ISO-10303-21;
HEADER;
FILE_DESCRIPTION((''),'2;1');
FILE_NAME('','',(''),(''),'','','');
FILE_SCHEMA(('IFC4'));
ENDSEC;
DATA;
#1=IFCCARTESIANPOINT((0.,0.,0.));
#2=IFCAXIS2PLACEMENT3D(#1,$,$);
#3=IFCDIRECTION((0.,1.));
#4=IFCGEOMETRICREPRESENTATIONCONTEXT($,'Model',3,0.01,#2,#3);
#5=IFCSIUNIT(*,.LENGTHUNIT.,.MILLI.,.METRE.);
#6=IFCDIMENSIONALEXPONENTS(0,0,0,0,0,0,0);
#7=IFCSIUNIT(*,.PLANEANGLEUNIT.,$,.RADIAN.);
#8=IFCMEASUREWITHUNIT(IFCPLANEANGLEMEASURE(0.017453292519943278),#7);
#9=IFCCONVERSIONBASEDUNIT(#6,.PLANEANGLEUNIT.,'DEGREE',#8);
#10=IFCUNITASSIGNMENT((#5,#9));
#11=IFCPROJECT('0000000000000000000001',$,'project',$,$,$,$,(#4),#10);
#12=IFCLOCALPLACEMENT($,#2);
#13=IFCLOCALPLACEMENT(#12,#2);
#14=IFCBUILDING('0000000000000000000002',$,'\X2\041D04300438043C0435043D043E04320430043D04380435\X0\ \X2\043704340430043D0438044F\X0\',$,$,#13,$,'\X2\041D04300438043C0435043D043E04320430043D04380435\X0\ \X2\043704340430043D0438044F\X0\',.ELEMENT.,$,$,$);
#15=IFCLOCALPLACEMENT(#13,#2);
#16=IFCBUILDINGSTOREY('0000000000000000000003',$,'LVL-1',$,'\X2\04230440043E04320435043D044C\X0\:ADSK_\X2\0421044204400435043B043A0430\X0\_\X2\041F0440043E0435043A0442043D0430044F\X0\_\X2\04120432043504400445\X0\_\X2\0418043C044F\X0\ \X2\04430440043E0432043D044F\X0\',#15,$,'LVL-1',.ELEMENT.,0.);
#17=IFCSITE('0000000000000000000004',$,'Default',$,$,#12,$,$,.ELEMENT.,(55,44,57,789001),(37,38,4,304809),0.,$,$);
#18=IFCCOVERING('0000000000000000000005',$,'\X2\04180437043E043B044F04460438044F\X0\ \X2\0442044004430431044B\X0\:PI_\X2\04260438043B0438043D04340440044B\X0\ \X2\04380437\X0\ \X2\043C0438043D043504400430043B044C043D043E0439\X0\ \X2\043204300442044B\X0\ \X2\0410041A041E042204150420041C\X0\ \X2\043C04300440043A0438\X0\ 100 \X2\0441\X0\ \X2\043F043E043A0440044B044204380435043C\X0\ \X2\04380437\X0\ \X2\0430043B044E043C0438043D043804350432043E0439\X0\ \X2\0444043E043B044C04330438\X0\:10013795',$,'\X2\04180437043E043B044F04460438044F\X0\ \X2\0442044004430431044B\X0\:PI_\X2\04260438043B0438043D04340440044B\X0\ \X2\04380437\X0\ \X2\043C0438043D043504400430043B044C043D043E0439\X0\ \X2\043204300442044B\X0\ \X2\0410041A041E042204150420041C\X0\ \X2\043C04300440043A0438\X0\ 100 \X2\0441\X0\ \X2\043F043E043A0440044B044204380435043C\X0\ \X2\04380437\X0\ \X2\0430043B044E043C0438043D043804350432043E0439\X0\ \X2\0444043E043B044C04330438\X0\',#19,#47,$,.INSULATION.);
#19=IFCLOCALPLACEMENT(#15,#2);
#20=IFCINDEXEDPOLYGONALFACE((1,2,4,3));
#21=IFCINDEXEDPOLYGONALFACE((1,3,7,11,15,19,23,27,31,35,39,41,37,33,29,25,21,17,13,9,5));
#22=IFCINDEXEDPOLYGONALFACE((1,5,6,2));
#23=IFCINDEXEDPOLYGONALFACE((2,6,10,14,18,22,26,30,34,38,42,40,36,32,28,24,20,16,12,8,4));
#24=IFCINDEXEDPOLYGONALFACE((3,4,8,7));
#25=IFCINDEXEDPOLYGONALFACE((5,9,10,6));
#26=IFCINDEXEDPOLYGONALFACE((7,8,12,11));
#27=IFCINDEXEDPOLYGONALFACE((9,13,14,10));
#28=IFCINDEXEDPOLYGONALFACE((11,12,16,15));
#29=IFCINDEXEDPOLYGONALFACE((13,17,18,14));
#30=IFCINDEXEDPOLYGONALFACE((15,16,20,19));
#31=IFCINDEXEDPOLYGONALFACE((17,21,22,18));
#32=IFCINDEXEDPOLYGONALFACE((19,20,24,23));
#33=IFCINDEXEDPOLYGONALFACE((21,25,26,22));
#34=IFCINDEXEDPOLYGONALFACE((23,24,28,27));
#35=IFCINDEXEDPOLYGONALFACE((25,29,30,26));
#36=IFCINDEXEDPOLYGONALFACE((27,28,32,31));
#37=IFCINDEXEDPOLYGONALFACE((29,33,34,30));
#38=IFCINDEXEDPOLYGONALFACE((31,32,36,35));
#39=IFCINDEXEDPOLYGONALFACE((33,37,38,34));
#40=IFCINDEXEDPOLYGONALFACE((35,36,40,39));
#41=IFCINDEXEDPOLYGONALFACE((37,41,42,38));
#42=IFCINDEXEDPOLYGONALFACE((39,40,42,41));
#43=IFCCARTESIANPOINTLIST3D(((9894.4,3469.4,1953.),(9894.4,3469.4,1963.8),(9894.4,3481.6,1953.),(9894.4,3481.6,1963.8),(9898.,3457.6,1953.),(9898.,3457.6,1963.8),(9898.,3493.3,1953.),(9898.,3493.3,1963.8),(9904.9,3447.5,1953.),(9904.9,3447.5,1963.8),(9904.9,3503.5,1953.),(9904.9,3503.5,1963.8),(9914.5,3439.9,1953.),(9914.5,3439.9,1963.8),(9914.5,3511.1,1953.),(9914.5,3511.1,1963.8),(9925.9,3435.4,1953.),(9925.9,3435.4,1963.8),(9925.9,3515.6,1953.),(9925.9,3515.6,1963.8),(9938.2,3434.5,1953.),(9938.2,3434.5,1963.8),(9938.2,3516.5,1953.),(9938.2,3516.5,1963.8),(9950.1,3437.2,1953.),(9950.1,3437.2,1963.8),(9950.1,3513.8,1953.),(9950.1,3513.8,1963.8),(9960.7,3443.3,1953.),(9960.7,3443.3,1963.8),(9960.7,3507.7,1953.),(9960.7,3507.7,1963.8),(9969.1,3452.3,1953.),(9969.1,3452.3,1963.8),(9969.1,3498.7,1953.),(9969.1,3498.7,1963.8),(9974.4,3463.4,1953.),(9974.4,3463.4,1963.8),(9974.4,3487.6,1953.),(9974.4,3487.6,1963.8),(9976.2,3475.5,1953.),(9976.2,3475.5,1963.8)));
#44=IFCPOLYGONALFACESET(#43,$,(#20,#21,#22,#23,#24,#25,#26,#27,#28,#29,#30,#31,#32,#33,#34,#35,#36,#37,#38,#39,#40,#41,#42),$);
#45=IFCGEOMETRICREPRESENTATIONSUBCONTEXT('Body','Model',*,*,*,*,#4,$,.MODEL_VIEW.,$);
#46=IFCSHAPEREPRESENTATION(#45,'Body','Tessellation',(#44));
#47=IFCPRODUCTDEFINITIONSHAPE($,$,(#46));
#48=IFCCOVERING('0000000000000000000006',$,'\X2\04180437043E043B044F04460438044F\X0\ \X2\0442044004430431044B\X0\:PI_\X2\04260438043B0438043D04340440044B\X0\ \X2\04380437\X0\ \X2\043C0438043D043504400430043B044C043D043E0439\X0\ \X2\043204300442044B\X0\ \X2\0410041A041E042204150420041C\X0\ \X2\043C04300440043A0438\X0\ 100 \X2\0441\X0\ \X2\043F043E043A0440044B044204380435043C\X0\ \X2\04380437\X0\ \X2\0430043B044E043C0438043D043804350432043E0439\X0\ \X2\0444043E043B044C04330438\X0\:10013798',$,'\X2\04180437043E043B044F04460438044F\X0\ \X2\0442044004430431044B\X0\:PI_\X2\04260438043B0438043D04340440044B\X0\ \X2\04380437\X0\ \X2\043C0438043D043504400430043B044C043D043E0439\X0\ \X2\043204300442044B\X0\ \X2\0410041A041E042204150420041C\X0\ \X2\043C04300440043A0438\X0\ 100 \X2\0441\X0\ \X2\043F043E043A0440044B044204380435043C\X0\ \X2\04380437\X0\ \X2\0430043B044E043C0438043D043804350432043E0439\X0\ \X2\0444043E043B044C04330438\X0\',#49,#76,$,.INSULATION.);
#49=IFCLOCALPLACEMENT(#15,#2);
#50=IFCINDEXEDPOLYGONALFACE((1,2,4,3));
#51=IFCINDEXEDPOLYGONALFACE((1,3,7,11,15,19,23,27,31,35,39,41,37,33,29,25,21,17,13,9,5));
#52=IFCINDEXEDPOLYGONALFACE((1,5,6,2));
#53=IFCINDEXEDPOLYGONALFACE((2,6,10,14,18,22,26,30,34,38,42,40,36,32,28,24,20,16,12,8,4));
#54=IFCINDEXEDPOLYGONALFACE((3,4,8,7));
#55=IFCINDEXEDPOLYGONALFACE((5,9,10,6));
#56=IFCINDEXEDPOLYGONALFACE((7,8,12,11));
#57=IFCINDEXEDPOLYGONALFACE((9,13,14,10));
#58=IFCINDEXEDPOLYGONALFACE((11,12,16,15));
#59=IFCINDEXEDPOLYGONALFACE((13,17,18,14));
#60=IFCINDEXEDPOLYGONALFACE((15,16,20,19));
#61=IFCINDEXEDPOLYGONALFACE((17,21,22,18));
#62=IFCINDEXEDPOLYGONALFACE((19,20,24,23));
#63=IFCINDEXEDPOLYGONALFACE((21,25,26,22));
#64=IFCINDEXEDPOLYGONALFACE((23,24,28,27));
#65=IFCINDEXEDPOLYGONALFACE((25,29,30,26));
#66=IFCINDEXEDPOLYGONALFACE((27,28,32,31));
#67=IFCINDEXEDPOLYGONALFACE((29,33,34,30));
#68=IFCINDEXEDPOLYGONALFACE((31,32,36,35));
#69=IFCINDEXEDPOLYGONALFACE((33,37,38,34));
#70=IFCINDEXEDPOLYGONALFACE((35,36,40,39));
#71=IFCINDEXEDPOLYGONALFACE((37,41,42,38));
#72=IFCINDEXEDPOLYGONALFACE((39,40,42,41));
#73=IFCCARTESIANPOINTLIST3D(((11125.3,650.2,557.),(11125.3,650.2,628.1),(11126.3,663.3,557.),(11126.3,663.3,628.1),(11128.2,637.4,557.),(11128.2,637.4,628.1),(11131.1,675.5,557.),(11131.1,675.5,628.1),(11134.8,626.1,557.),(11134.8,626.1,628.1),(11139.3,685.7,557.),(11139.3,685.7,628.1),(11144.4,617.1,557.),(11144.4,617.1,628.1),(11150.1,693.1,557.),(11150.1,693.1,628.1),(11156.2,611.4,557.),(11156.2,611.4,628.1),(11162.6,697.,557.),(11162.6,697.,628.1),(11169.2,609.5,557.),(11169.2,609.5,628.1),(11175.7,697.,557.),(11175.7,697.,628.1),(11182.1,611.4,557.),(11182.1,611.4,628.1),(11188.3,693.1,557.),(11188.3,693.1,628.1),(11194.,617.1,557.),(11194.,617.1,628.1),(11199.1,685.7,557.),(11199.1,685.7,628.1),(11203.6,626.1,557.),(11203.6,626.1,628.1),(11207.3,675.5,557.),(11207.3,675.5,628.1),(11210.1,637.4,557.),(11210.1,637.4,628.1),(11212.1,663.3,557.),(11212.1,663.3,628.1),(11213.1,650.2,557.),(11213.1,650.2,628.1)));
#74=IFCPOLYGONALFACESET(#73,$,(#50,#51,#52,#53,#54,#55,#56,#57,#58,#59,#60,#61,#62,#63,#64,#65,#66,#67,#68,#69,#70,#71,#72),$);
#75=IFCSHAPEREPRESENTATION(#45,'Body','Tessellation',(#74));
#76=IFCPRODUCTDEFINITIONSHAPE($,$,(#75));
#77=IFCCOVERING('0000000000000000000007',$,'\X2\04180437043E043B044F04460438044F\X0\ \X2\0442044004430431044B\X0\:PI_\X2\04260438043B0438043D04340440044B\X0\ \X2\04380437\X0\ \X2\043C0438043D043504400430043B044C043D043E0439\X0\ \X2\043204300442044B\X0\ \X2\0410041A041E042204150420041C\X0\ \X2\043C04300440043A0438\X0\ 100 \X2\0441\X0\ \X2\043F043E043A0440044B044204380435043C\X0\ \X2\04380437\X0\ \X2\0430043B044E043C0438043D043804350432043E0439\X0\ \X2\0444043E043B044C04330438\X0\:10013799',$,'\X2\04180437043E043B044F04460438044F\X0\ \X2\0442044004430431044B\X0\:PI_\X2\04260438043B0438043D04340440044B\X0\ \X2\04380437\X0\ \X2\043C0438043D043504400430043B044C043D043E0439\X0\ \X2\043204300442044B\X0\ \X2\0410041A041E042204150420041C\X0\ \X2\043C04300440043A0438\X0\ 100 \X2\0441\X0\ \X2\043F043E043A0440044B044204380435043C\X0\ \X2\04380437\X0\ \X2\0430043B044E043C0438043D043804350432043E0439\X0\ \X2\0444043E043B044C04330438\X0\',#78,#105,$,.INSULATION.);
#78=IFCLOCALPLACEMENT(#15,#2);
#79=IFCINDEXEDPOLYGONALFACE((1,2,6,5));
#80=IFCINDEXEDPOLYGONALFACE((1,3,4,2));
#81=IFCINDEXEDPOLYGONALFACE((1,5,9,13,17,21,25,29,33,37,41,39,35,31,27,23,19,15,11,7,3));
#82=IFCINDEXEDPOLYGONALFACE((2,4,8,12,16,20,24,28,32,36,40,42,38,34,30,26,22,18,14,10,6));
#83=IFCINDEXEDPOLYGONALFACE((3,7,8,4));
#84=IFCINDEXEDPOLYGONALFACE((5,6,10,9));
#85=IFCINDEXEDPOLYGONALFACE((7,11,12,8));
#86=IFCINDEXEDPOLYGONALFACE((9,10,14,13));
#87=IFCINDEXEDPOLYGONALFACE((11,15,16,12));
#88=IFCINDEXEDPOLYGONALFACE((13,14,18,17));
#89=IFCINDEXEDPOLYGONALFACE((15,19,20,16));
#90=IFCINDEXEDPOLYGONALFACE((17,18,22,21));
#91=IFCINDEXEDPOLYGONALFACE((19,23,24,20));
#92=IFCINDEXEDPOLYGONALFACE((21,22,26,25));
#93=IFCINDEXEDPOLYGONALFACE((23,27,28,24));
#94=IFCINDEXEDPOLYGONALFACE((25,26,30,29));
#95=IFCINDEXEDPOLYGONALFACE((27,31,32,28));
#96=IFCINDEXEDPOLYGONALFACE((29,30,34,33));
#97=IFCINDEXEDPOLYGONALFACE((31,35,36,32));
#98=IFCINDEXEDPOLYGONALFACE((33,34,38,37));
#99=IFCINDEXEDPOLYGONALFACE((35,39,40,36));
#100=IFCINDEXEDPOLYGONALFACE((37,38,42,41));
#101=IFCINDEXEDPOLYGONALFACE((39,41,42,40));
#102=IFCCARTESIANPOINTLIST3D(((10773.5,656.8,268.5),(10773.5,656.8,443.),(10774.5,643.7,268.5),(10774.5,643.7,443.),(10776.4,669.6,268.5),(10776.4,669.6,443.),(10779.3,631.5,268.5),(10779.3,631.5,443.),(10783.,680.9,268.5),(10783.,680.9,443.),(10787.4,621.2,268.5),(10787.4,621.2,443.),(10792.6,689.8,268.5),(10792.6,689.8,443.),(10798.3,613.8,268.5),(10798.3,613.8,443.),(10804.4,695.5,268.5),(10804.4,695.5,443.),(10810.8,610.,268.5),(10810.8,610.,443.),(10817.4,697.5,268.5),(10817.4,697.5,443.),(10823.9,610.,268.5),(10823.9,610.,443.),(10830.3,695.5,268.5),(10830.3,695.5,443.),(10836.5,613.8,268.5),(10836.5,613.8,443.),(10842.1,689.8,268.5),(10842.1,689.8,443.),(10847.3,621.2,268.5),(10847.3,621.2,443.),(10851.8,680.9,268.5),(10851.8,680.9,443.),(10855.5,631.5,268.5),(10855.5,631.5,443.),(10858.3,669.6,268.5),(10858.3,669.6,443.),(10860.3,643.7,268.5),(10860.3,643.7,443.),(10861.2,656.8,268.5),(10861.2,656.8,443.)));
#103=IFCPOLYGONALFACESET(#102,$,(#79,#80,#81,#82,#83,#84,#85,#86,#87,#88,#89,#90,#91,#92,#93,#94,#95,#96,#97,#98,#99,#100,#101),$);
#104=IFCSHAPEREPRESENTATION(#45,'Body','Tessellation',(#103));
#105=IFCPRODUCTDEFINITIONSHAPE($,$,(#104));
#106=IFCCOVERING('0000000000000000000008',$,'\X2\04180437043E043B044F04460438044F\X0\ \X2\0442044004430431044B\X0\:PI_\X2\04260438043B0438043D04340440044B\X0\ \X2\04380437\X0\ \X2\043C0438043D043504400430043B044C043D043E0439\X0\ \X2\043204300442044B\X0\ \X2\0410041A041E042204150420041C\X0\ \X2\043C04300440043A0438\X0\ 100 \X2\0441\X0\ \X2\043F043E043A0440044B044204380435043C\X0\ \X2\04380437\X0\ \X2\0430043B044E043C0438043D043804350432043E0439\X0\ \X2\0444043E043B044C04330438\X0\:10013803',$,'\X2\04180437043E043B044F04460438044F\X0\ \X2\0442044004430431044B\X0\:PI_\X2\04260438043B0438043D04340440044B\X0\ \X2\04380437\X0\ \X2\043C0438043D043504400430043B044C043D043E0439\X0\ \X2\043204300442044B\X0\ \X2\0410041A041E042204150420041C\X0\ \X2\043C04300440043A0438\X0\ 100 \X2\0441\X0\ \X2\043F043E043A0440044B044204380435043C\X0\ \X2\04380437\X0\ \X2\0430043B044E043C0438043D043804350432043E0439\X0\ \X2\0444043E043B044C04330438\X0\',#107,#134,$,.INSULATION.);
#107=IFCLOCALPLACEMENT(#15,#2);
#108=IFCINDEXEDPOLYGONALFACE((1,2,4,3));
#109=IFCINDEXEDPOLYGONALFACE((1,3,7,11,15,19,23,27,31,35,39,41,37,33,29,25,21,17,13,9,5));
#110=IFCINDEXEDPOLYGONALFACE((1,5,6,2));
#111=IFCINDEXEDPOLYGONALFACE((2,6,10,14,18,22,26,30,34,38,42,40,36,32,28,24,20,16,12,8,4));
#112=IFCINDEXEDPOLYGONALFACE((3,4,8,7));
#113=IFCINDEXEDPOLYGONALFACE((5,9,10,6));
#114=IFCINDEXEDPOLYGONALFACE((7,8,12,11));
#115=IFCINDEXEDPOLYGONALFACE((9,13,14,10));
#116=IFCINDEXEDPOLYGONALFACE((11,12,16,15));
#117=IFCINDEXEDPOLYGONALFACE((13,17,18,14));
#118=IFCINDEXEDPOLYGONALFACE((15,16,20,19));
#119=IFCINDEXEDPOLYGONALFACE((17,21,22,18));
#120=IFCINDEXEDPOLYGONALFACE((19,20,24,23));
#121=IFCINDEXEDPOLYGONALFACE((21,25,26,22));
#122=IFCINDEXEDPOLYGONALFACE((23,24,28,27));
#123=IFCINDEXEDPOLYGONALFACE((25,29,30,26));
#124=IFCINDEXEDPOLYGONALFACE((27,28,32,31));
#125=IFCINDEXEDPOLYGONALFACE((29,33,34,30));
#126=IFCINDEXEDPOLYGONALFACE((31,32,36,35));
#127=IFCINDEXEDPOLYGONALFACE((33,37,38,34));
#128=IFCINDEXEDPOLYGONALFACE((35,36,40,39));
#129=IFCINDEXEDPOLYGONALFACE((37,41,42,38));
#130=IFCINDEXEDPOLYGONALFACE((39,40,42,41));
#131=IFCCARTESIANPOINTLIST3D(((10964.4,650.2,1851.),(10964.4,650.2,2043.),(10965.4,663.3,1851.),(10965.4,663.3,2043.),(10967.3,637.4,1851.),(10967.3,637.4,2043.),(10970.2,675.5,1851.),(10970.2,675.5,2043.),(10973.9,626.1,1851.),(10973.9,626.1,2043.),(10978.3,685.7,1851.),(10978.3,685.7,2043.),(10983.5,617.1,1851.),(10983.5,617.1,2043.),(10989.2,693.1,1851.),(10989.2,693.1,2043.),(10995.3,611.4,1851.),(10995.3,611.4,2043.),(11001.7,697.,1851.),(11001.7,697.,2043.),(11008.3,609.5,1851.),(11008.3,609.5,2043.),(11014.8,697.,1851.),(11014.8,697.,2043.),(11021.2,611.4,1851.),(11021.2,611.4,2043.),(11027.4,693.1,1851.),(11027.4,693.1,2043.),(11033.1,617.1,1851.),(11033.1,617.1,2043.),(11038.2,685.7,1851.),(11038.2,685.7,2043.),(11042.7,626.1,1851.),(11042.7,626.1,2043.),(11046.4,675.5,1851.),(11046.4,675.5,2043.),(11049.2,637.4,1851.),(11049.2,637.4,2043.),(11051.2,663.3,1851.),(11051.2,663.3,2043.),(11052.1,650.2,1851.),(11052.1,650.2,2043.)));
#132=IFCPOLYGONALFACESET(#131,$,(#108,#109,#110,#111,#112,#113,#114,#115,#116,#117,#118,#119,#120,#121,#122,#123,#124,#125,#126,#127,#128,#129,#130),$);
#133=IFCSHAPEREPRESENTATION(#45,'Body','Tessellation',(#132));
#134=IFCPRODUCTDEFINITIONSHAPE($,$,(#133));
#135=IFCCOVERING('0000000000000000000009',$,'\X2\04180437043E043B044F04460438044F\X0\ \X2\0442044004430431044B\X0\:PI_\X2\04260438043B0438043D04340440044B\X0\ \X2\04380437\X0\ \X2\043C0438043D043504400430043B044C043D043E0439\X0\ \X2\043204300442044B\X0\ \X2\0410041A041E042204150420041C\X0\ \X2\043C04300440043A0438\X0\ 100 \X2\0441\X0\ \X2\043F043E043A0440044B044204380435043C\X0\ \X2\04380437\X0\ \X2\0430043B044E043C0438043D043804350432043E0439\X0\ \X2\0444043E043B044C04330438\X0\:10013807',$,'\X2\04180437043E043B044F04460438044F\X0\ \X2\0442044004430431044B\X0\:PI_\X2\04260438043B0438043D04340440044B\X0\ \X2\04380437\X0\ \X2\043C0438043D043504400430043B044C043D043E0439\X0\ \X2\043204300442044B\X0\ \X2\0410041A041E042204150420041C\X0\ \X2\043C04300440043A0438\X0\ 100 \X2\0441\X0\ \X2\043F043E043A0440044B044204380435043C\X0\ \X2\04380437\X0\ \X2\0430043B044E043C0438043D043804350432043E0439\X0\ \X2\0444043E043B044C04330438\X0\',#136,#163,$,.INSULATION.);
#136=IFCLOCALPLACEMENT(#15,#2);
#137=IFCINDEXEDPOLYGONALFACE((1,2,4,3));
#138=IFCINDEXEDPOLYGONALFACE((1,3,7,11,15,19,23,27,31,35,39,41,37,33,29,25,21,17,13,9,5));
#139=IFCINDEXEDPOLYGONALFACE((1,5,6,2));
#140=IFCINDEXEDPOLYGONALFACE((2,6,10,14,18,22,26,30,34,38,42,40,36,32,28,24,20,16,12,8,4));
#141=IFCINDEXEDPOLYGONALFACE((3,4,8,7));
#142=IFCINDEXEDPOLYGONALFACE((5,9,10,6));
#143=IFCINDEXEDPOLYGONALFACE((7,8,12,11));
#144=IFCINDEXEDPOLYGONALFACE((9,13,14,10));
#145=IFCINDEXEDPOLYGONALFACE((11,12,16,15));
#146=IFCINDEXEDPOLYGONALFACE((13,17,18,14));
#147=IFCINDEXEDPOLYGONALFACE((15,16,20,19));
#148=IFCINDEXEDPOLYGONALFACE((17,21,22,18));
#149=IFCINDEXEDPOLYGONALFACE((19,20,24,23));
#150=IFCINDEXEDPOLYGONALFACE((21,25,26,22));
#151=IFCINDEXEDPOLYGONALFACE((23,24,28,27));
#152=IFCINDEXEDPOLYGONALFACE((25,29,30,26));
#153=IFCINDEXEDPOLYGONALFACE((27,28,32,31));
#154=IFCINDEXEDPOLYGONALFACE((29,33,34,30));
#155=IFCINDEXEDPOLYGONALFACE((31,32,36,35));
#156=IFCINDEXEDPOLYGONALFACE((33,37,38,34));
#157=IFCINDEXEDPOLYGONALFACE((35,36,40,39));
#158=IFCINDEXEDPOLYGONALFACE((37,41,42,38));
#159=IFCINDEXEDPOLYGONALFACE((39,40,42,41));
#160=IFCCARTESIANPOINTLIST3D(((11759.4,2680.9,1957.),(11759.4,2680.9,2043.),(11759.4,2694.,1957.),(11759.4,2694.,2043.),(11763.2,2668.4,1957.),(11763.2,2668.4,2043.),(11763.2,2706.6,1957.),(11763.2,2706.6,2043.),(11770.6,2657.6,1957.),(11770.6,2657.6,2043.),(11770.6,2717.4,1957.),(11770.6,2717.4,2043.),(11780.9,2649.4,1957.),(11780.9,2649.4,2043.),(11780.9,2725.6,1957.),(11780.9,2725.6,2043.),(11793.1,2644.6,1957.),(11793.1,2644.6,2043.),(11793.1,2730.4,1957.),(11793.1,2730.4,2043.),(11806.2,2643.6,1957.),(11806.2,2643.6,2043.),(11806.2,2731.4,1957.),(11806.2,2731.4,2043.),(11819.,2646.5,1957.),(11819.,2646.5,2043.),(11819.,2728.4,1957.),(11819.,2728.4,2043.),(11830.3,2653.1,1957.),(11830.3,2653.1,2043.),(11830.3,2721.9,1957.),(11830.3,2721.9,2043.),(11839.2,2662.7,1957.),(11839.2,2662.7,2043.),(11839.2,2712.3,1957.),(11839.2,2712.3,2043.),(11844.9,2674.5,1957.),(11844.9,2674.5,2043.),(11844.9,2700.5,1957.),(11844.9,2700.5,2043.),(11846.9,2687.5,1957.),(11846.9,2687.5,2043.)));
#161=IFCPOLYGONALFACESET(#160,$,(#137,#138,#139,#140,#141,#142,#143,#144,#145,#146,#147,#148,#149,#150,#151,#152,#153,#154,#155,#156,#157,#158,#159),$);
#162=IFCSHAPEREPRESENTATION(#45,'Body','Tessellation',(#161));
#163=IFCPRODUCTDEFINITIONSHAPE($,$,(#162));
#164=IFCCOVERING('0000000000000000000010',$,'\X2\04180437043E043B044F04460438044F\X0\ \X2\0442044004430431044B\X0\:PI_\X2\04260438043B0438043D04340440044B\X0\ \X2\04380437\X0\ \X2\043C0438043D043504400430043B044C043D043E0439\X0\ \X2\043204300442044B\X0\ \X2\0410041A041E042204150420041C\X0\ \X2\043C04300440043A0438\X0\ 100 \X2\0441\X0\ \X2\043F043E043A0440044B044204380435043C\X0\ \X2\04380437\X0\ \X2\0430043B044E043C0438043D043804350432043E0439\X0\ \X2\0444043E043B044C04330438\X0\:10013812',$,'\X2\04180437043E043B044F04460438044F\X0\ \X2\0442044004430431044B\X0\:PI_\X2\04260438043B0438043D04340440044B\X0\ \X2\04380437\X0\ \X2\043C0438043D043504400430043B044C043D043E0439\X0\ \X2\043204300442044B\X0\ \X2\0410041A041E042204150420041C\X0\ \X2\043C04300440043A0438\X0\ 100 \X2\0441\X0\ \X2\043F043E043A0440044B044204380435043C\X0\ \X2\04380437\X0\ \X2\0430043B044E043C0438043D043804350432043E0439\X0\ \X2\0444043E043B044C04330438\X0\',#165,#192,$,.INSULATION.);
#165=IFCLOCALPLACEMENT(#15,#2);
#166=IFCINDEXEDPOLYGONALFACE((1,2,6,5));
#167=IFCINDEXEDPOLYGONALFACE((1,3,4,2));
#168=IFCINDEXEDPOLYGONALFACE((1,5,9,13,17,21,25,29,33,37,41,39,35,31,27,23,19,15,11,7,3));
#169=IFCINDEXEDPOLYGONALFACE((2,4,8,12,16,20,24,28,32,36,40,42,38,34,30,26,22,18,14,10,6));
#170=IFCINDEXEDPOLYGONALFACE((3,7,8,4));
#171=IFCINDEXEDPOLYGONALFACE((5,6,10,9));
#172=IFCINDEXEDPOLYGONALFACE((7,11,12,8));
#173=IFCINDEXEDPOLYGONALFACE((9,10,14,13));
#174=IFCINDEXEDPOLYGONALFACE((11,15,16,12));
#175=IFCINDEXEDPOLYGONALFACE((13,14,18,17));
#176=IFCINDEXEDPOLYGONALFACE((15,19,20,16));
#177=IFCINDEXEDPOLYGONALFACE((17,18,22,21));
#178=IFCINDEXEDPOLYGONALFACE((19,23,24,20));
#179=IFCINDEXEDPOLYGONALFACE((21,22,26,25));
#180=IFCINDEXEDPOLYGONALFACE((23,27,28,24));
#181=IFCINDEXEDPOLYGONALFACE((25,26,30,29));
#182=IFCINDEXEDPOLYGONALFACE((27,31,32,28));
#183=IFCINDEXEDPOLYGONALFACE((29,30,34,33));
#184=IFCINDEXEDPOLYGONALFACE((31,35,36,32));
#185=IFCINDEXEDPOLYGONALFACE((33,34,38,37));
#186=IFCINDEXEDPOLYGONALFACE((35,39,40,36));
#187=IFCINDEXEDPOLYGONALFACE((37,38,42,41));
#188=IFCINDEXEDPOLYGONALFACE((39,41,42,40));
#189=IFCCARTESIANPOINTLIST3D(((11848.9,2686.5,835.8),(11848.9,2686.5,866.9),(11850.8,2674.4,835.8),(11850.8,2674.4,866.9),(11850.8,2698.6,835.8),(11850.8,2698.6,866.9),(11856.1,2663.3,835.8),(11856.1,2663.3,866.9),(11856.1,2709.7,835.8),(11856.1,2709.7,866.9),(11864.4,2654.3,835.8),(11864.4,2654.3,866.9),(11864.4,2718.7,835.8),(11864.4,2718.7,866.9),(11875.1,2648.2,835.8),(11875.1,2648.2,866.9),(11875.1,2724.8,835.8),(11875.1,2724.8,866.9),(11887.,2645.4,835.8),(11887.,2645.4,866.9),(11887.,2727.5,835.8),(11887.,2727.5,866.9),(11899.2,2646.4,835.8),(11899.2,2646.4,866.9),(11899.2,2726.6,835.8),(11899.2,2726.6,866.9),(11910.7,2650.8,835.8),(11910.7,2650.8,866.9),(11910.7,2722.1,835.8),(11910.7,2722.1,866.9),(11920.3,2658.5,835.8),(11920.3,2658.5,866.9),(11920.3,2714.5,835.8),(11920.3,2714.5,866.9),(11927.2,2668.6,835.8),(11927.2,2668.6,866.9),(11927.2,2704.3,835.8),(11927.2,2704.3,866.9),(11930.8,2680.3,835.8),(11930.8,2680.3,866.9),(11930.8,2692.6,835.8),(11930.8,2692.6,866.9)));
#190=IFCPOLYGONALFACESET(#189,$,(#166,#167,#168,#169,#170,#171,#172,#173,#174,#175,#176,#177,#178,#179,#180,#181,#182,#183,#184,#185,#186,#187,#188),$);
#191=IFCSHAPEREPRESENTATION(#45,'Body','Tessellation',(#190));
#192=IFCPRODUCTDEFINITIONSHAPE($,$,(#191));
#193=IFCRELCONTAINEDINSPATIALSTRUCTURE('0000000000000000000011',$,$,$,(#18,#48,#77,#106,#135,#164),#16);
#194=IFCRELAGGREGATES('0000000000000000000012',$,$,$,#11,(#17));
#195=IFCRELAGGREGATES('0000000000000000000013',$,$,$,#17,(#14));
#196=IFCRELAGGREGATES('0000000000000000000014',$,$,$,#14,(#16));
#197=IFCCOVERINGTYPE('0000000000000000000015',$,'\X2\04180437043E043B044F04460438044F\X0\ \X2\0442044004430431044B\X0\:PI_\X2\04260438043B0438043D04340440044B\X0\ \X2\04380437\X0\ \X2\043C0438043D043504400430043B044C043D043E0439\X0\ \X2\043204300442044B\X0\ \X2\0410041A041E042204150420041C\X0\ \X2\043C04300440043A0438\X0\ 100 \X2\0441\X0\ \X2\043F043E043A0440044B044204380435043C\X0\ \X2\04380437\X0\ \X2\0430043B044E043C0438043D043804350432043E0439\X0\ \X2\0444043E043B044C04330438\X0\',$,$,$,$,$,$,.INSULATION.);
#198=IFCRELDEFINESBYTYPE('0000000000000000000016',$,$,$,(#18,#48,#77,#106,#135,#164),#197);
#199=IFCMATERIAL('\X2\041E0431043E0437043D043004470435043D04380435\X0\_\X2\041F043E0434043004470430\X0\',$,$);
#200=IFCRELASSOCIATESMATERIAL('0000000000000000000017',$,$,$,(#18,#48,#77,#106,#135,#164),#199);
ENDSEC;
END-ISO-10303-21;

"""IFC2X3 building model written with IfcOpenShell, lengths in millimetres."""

from ifc_helpers import new_model, entity, si_unit, converted_unit, direction, frame, frame_2d, origin, origin_2d_with_axis, place, context, subcontext, project, spatial, circle, extrude, material, type_object, element, save


model = new_model("IFC2X3")

# Units and contexts
model_context = context("Model", 3, precision=0.01, world=origin(), true_north=direction((0.0, 1.0)))
body_context = subcontext(model_context, "Body", "Model", "MODEL_VIEW")
ifc_project = project(units=[si_unit("LENGTHUNIT", "METRE", prefix="MILLI"), converted_unit("PLANEANGLEUNIT", "DEGREE", entity("IfcPlaneAngleMeasure", 0.017453292519943278), si_unit("PLANEANGLEUNIT", "RADIAN"), dimensions=[0, 0, 0, 0, 0, 0, 0])], contexts=[model_context])

# Site, building, storey
site_placement = place(None, origin())
site = spatial("IfcSite", under=ifc_project, at=site_placement, Name="Default", CompositionType="ELEMENT", RefLatitude=(55, 44, 57, 789001), RefLongitude=(37, 38, 4, 304809), RefElevation=0.0)
building_placement = place(site_placement, origin())
building = spatial("IfcBuilding", under=site, at=building_placement, Name="Наименование здания", LongName="Наименование здания", CompositionType="ELEMENT")
storey_placement = place(building_placement, origin())
storey = spatial("IfcBuildingStorey", under=building, at=storey_placement, Name="LVL-1", ObjectType="Уровень:ADSK_Стрелка_Проектная_Вверх_Имя уровня", LongName="LVL-1", CompositionType="ELEMENT", Elevation=0.0)

# Coverings
ifc_material_1 = material(Name="Обозначение_Подача")
covering_type = type_object("IfcCoveringType", Name="Изоляция трубы:PI_Цилиндры из минеральной ваты АКОТЕРМ марки 100 с покрытием из алюминиевой фольги", PredefinedType="INSULATION")
covering_1_placement = place(storey_placement, origin())
element("IfcCovering", 1, at=covering_1_placement, inside=storey, type_object=covering_type, material=ifc_material_1, Name="Изоляция трубы:PI_Цилиндры из минеральной ваты АКОТЕРМ марки 100 с покрытием из алюминиевой фольги:10013795", ObjectType="Изоляция трубы:PI_Цилиндры из минеральной ваты АКОТЕРМ марки 100 с покрытием из алюминиевой фольги", PredefinedType="INSULATION", context=body_context, shape_type="SweptSolid", body=[
    extrude(circle(Radius=41.1, at=frame_2d((0.0, 0.0), x_axis=(1.0, 0.0))), frame((9935.1, 3475.5, 1953.0)), (0.0, 0.0, 1.0), 10.8),
])
covering_2_placement = place(storey_placement, origin())
element("IfcCovering", 2, at=covering_2_placement, inside=storey, type_object=covering_type, material=ifc_material_1, Name="Изоляция трубы:PI_Цилиндры из минеральной ваты АКОТЕРМ марки 100 с покрытием из алюминиевой фольги:10013798", ObjectType="Изоляция трубы:PI_Цилиндры из минеральной ваты АКОТЕРМ марки 100 с покрытием из алюминиевой фольги", PredefinedType="INSULATION", context=body_context, shape_type="SweptSolid", body=[
    extrude(circle(Radius=44.0, at=origin_2d_with_axis()), frame((11169.2, 653.5, 557.0), z_axis=(0.0, 0.0, 1.0), x_axis=(0.0, -1.0, 0.0)), (0.0, 0.0, 1.0), 71.1),
])
covering_3_placement = place(storey_placement, origin())
element("IfcCovering", 3, at=covering_3_placement, inside=storey, type_object=covering_type, material=ifc_material_1, Name="Изоляция трубы:PI_Цилиндры из минеральной ваты АКОТЕРМ марки 100 с покрытием из алюминиевой фольги:10013799", ObjectType="Изоляция трубы:PI_Цилиндры из минеральной ваты АКОТЕРМ марки 100 с покрытием из алюминиевой фольги", PredefinedType="INSULATION", context=body_context, shape_type="SweptSolid", body=[
    extrude(circle(Radius=44.0, at=frame_2d((0.0, 0.0), x_axis=(1.0, 0.0))), frame((10817.4, 653.5, 268.5), z_axis=(0.0, 0.0, 1.0), x_axis=(0.0, 1.0, 0.0)), (0.0, 0.0, 1.0), 174.5),
])
covering_4_placement = place(storey_placement, origin())
element("IfcCovering", 4, at=covering_4_placement, inside=storey, type_object=covering_type, material=ifc_material_1, Name="Изоляция трубы:PI_Цилиндры из минеральной ваты АКОТЕРМ марки 100 с покрытием из алюминиевой фольги:10013803", ObjectType="Изоляция трубы:PI_Цилиндры из минеральной ваты АКОТЕРМ марки 100 с покрытием из алюминиевой фольги", PredefinedType="INSULATION", context=body_context, shape_type="SweptSolid", body=[
    extrude(circle(Radius=44.0, at=frame_2d((0.0, 0.0), x_axis=(1.0, 0.0))), frame((11008.3, 653.5, 1851.0), z_axis=(0.0, 0.0, 1.0), x_axis=(0.0, -1.0, 0.0)), (0.0, 0.0, 1.0), 192.0),
])
covering_5_placement = place(storey_placement, origin())
element("IfcCovering", 5, at=covering_5_placement, inside=storey, type_object=covering_type, material=ifc_material_1, Name="Изоляция трубы:PI_Цилиндры из минеральной ваты АКОТЕРМ марки 100 с покрытием из алюминиевой фольги:10013807", ObjectType="Изоляция трубы:PI_Цилиндры из минеральной ваты АКОТЕРМ марки 100 с покрытием из алюминиевой фольги", PredefinedType="INSULATION", context=body_context, shape_type="SweptSolid", body=[
    extrude(circle(Radius=44.0, at=origin_2d_with_axis()), frame((11802.9, 2687.5, 1957.0)), (0.0, 0.0, 1.0), 86.0),
])
covering_6_placement = place(storey_placement, origin())
element("IfcCovering", 6, at=covering_6_placement, inside=storey, type_object=covering_type, material=ifc_material_1, Name="Изоляция трубы:PI_Цилиндры из минеральной ваты АКОТЕРМ марки 100 с покрытием из алюминиевой фольги:10013812", ObjectType="Изоляция трубы:PI_Цилиндры из минеральной ваты АКОТЕРМ марки 100 с покрытием из алюминиевой фольги", PredefinedType="INSULATION", context=body_context, shape_type="SweptSolid", body=[
    extrude(circle(Radius=41.1, at=frame_2d((0.0, 0.0), x_axis=(1.0, 0.0))), frame((11890.1, 2686.5, 835.8), z_axis=(0.0, 0.0, 1.0), x_axis=(-1.0, 0.0, 0.0)), (0.0, 0.0, 1.0), 31.1),
])

save(model, "model.ifc")
